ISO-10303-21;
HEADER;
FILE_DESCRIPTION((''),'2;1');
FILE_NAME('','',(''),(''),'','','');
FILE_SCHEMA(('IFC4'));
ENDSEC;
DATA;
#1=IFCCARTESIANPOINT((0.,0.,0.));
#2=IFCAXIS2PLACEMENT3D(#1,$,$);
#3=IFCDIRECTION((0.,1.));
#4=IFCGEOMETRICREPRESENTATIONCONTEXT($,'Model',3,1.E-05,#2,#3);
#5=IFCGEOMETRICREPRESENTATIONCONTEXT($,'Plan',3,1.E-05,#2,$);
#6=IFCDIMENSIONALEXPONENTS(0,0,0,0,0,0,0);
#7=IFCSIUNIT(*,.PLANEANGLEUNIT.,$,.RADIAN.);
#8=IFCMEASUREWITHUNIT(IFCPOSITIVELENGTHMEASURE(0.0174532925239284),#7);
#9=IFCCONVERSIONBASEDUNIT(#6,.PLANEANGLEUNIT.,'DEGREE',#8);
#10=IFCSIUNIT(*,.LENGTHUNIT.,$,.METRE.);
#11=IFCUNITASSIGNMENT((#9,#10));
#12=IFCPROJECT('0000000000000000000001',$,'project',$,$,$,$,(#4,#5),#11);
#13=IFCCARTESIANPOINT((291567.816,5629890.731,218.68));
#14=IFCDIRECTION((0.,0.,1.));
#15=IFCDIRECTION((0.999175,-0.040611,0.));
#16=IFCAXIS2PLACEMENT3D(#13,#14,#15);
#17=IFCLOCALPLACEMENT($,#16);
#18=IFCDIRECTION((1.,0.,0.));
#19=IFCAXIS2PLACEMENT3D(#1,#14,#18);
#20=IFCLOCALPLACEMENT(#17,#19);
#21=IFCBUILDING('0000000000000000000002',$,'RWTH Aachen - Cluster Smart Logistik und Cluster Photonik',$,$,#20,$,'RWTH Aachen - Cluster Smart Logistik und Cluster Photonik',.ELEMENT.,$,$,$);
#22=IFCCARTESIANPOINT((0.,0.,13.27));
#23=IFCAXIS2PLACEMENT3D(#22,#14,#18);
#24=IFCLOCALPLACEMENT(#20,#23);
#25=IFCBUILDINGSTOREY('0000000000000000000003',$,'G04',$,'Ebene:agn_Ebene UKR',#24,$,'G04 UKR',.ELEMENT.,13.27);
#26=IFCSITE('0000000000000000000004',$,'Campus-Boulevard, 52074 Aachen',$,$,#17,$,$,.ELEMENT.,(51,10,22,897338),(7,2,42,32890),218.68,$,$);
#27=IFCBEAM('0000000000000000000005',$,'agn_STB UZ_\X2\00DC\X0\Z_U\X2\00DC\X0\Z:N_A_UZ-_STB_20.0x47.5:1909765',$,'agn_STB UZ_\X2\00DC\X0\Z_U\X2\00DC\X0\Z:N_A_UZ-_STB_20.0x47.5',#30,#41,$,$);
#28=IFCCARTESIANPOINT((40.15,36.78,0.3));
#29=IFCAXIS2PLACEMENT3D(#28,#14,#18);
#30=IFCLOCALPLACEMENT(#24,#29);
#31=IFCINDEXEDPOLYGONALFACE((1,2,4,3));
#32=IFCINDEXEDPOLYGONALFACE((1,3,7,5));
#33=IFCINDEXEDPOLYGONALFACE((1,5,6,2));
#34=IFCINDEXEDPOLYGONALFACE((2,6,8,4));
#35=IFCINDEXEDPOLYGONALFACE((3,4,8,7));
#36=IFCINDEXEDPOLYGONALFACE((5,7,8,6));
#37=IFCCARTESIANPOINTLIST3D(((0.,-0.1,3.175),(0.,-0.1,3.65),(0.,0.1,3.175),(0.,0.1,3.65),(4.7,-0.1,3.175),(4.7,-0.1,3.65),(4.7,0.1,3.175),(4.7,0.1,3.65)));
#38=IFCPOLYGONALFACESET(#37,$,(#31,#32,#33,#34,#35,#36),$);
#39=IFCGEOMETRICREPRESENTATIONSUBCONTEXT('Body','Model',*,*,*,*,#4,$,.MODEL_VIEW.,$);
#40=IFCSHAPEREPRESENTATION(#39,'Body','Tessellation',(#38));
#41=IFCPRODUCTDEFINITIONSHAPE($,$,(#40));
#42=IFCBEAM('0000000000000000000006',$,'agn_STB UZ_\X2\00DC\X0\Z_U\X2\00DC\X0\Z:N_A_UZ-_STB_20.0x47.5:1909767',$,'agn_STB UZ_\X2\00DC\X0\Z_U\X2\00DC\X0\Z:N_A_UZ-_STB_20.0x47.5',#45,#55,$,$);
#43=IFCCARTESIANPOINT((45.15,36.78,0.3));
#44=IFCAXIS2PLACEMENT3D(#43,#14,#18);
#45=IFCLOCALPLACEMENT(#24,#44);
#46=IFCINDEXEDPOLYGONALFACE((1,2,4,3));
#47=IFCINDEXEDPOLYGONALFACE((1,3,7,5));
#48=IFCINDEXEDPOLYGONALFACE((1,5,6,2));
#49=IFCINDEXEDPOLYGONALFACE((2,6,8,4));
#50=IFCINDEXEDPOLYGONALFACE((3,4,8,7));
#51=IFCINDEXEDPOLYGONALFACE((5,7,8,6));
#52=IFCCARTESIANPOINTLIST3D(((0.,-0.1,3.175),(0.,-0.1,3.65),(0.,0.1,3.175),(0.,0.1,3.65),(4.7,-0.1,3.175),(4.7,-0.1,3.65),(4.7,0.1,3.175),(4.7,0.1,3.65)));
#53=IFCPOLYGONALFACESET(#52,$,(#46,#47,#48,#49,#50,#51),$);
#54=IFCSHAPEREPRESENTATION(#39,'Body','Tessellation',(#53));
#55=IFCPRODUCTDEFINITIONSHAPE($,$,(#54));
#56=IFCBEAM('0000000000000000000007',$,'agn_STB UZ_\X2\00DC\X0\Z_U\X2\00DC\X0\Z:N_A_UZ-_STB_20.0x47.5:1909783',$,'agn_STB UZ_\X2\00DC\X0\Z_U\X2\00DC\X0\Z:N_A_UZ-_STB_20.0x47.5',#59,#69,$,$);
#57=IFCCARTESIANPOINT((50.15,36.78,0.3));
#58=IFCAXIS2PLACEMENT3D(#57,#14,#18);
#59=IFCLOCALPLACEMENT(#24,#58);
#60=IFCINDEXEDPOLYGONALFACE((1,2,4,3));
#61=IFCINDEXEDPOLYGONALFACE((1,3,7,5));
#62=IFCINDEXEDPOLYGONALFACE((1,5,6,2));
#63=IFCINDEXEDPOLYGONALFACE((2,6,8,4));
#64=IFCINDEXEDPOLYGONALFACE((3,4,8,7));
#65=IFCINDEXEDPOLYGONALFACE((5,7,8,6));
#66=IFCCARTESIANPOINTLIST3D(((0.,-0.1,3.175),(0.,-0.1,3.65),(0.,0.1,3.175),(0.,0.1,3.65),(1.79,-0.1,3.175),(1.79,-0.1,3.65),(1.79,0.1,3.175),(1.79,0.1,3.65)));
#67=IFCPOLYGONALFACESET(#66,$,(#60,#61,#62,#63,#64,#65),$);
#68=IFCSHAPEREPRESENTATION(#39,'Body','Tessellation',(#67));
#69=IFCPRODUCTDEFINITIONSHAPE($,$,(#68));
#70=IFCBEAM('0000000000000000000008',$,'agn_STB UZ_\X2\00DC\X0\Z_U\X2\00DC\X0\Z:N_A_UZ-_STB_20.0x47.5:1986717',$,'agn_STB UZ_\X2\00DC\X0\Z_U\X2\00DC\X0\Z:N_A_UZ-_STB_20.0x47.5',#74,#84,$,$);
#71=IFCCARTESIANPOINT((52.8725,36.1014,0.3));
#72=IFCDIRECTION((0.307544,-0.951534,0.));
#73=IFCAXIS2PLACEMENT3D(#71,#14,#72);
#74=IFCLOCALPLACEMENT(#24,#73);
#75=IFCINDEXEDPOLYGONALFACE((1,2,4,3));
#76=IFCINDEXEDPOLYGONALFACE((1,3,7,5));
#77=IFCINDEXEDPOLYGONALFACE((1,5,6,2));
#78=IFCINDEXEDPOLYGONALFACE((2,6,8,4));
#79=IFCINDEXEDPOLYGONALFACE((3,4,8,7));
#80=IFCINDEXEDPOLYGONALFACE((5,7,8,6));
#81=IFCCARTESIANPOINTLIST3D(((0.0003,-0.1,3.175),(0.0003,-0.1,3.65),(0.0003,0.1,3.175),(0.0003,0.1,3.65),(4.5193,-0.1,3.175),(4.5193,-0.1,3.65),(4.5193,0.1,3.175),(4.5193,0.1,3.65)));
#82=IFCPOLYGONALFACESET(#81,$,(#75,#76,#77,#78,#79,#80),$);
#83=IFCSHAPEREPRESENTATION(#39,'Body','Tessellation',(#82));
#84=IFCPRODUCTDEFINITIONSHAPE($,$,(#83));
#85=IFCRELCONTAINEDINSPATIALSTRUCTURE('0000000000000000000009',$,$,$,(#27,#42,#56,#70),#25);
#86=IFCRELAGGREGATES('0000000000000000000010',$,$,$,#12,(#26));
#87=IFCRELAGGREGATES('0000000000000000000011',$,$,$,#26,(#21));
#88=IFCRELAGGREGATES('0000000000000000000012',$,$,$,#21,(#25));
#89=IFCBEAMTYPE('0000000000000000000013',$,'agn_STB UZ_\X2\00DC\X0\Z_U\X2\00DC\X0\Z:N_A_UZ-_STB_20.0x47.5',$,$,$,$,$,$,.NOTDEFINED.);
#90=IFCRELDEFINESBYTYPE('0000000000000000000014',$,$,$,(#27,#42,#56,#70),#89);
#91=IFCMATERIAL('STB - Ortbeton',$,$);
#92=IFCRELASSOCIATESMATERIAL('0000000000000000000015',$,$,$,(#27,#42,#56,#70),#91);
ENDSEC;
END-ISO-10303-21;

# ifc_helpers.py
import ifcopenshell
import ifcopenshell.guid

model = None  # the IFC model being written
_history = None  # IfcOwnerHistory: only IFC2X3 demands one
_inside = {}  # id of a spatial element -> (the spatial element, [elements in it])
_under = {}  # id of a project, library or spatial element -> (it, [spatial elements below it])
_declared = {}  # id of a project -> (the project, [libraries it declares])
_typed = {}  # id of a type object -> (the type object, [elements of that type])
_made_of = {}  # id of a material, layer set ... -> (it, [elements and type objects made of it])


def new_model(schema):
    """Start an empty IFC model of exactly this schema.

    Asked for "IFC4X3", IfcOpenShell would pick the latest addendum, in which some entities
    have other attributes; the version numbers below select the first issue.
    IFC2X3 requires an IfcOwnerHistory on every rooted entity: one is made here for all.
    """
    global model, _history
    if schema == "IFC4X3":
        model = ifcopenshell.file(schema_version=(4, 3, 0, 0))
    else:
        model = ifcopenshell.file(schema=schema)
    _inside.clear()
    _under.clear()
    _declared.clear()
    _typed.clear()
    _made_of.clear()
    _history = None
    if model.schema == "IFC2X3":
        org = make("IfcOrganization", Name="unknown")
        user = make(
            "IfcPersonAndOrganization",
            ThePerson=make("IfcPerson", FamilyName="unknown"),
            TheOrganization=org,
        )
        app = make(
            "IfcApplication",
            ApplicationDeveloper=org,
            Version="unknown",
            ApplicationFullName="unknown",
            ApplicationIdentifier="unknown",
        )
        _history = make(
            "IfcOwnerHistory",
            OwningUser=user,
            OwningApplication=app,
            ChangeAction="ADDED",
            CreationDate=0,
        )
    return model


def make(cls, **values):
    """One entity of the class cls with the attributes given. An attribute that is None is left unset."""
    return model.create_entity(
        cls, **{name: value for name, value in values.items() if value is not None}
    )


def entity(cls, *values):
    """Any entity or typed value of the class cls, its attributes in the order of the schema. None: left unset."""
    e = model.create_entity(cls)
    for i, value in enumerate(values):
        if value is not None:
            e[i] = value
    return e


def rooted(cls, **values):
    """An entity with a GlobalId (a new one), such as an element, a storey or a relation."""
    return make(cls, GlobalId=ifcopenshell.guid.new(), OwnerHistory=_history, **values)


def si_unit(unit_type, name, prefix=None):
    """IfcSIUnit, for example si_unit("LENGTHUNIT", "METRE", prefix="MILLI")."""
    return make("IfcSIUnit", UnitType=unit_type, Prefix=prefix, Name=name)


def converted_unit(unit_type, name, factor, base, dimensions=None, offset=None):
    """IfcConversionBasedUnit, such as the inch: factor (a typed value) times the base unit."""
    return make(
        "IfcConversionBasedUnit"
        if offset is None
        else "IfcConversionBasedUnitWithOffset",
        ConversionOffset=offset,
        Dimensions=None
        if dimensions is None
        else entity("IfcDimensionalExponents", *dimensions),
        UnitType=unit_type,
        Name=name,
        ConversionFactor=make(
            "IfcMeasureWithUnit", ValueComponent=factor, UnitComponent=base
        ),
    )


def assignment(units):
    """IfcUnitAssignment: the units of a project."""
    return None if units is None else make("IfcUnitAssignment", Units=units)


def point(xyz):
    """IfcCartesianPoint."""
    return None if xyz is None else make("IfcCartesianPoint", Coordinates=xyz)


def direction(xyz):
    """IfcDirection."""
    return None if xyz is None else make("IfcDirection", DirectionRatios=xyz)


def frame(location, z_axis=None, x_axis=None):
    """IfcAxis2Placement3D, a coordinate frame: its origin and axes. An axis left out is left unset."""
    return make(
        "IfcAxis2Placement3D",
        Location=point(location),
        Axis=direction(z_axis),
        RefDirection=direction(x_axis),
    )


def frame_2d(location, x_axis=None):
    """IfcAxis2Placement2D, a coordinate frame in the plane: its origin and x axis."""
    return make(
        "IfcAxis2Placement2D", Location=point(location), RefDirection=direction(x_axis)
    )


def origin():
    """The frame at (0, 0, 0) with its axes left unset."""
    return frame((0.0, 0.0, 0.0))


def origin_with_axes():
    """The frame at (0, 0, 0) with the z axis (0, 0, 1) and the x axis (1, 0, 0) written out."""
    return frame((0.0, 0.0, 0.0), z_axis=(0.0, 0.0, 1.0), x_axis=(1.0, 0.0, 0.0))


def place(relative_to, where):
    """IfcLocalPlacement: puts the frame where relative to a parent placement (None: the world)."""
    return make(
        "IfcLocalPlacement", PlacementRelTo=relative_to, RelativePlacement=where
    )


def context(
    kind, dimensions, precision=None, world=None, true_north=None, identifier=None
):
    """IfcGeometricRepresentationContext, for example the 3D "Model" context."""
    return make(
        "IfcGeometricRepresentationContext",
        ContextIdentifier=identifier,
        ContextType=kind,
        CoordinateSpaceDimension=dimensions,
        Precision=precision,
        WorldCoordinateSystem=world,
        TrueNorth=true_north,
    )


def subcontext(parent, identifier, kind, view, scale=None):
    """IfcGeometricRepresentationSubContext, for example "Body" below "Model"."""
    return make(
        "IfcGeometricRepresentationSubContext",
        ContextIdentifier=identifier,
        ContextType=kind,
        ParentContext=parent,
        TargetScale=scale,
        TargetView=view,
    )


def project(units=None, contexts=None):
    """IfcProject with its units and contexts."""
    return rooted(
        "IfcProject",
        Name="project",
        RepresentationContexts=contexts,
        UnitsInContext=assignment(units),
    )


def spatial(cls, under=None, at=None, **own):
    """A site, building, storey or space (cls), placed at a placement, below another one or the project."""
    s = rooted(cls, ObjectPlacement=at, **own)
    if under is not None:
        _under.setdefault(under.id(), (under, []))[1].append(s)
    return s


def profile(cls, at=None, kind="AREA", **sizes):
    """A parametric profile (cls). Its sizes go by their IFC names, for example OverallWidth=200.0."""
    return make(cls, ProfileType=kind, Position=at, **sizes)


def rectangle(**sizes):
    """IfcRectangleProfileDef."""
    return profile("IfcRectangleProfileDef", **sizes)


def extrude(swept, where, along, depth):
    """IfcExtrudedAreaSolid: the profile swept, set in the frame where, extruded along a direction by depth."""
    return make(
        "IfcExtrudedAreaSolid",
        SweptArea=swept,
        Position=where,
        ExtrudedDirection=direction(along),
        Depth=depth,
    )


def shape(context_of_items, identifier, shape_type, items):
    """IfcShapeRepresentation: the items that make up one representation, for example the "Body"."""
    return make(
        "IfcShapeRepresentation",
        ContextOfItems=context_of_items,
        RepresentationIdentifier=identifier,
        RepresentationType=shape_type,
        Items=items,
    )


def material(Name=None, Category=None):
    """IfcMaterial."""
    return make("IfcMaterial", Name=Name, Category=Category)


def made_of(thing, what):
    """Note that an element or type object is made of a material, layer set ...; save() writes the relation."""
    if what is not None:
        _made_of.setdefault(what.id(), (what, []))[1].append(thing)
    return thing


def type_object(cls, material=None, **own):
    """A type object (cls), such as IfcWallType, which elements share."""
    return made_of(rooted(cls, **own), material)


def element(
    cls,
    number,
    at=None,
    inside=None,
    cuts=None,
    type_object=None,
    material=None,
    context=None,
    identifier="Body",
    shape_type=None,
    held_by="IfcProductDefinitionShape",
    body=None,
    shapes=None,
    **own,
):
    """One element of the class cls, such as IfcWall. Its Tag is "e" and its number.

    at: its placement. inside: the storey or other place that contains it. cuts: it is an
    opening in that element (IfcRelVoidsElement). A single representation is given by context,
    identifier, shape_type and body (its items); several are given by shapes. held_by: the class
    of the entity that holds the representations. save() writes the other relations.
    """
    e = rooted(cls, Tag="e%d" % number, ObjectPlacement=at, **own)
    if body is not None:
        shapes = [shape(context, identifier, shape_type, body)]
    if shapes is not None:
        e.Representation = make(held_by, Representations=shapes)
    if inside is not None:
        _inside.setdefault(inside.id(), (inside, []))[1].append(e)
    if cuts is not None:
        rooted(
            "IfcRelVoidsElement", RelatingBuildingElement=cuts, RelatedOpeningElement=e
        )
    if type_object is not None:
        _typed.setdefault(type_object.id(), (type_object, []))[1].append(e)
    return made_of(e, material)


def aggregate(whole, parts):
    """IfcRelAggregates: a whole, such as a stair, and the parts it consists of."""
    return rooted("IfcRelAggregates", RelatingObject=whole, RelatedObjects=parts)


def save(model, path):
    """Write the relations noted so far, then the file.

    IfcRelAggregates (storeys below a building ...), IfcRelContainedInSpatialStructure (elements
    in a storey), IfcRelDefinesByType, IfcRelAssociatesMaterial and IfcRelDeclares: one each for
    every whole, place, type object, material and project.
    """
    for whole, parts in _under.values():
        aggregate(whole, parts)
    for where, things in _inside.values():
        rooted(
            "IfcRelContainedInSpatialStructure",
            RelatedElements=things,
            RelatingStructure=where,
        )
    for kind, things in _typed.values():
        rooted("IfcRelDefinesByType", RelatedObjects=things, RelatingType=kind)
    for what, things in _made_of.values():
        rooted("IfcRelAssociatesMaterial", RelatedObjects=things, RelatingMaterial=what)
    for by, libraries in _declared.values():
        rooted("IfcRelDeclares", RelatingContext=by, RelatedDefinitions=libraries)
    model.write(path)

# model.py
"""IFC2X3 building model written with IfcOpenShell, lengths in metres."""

from ifc_helpers import new_model, entity, si_unit, converted_unit, direction, frame, frame_2d, origin, origin_with_axes, place, context, subcontext, project, spatial, rectangle, extrude, material, type_object, element, save


model = new_model("IFC2X3")

# Units and contexts
model_context = context("Model", 3, precision=1e-05, world=origin(), true_north=direction((0.0, 1.0)))
plan_context = context("Plan", 3, precision=1e-05, world=origin())
body_context = subcontext(model_context, "Body", "Model", "MODEL_VIEW")
ifc_project = project(units=[converted_unit("PLANEANGLEUNIT", "DEGREE", entity("IfcPositiveLengthMeasure", 0.0174532925239284), si_unit("PLANEANGLEUNIT", "RADIAN"), dimensions=[0, 0, 0, 0, 0, 0, 0]), si_unit("LENGTHUNIT", "METRE")], contexts=[model_context, plan_context])

# Site, building, storey
site_placement = place(None, frame((291567.816, 5629890.731, 218.68), z_axis=(0.0, 0.0, 1.0), x_axis=(0.999175, -0.040611, 0.0)))
site = spatial("IfcSite", under=ifc_project, at=site_placement, Name="Campus-Boulevard, 52074 Aachen", CompositionType="ELEMENT", RefLatitude=(51, 10, 22, 897338), RefLongitude=(7, 2, 42, 32890), RefElevation=218.68)
building_placement = place(site_placement, origin_with_axes())
building = spatial("IfcBuilding", under=site, at=building_placement, Name="RWTH Aachen - Cluster Smart Logistik und Cluster Photonik", LongName="RWTH Aachen - Cluster Smart Logistik und Cluster Photonik", CompositionType="ELEMENT")
storey_placement = place(building_placement, frame((0.0, 0.0, 13.27), z_axis=(0.0, 0.0, 1.0), x_axis=(1.0, 0.0, 0.0)))
storey = spatial("IfcBuildingStorey", under=building, at=storey_placement, Name="G04", ObjectType="Ebene:agn_Ebene UKR", LongName="G04 UKR", CompositionType="ELEMENT", Elevation=13.27)

# Beams
ifc_material_1 = material(Name="STB - Ortbeton")
beam_type_1 = type_object("IfcBeamType", Name="agn_STB UZ_ÜZ_UÜZ:N_A_UZ-_STB_20.0x47.5", PredefinedType="NOTDEFINED")
for number, where, z_axis, x_axis, name in (
    (1, (40.15, 36.78, 0.3), (0.0, 0.0, 1.0), (1.0, 0.0, 0.0), "agn_STB UZ_ÜZ_UÜZ:N_A_UZ-_STB_20.0x47.5:1909765"),
    (2, (45.15, 36.78, 0.3), (0.0, 0.0, 1.0), (1.0, 0.0, 0.0), "agn_STB UZ_ÜZ_UÜZ:N_A_UZ-_STB_20.0x47.5:1909767"),
):
    element("IfcBeam", number, at=place(storey_placement, frame(where, z_axis=z_axis, x_axis=x_axis)), inside=storey, type_object=beam_type_1, material=ifc_material_1, Name=name, ObjectType="agn_STB UZ_ÜZ_UÜZ:N_A_UZ-_STB_20.0x47.5", context=body_context, shape_type="SweptSolid", body=[
        extrude(rectangle(XDim=0.475, YDim=0.2, at=frame_2d((0.0, 0.0), x_axis=(1.0, 0.0))), frame((0.0, 0.0, 3.4125), z_axis=(1.0, 0.0, 0.0), x_axis=(0.0, 0.0, -1.0)), (0.0, 0.0, 1.0), 4.7),
    ])
beam_1_placement = place(storey_placement, frame((50.15, 36.78, 0.3), z_axis=(0.0, 0.0, 1.0), x_axis=(1.0, 0.0, 0.0)))
element("IfcBeam", 3, at=beam_1_placement, inside=storey, type_object=beam_type_1, material=ifc_material_1, Name="agn_STB UZ_ÜZ_UÜZ:N_A_UZ-_STB_20.0x47.5:1909783", ObjectType="agn_STB UZ_ÜZ_UÜZ:N_A_UZ-_STB_20.0x47.5", context=body_context, shape_type="SweptSolid", body=[
    extrude(rectangle(XDim=0.475, YDim=0.2, at=frame_2d((0.0, 0.0), x_axis=(1.0, 0.0))), frame((0.0, 0.0, 3.4125), z_axis=(1.0, 0.0, 0.0), x_axis=(0.0, 0.0, -1.0)), (0.0, 0.0, 1.0), 1.79),
])
beam_2_placement = place(storey_placement, frame((52.8725, 36.1014, 0.3), z_axis=(0.0, 0.0, 1.0), x_axis=(0.307544, -0.951534, 0.0)))
element("IfcBeam", 4, at=beam_2_placement, inside=storey, type_object=beam_type_1, material=ifc_material_1, Name="agn_STB UZ_ÜZ_UÜZ:N_A_UZ-_STB_20.0x47.5:1986717", ObjectType="agn_STB UZ_ÜZ_UÜZ:N_A_UZ-_STB_20.0x47.5", context=body_context, shape_type="SweptSolid", body=[
    extrude(rectangle(XDim=0.475, YDim=0.2, at=frame_2d((0.0, 0.0), x_axis=(1.0, 0.0))), frame((0.0003, 0.0, 3.4125), z_axis=(1.0, 0.0, 0.0), x_axis=(0.0, 0.0, -1.0)), (0.0, 0.0, 1.0), 4.519),
])

save(model, "model.ifc")
